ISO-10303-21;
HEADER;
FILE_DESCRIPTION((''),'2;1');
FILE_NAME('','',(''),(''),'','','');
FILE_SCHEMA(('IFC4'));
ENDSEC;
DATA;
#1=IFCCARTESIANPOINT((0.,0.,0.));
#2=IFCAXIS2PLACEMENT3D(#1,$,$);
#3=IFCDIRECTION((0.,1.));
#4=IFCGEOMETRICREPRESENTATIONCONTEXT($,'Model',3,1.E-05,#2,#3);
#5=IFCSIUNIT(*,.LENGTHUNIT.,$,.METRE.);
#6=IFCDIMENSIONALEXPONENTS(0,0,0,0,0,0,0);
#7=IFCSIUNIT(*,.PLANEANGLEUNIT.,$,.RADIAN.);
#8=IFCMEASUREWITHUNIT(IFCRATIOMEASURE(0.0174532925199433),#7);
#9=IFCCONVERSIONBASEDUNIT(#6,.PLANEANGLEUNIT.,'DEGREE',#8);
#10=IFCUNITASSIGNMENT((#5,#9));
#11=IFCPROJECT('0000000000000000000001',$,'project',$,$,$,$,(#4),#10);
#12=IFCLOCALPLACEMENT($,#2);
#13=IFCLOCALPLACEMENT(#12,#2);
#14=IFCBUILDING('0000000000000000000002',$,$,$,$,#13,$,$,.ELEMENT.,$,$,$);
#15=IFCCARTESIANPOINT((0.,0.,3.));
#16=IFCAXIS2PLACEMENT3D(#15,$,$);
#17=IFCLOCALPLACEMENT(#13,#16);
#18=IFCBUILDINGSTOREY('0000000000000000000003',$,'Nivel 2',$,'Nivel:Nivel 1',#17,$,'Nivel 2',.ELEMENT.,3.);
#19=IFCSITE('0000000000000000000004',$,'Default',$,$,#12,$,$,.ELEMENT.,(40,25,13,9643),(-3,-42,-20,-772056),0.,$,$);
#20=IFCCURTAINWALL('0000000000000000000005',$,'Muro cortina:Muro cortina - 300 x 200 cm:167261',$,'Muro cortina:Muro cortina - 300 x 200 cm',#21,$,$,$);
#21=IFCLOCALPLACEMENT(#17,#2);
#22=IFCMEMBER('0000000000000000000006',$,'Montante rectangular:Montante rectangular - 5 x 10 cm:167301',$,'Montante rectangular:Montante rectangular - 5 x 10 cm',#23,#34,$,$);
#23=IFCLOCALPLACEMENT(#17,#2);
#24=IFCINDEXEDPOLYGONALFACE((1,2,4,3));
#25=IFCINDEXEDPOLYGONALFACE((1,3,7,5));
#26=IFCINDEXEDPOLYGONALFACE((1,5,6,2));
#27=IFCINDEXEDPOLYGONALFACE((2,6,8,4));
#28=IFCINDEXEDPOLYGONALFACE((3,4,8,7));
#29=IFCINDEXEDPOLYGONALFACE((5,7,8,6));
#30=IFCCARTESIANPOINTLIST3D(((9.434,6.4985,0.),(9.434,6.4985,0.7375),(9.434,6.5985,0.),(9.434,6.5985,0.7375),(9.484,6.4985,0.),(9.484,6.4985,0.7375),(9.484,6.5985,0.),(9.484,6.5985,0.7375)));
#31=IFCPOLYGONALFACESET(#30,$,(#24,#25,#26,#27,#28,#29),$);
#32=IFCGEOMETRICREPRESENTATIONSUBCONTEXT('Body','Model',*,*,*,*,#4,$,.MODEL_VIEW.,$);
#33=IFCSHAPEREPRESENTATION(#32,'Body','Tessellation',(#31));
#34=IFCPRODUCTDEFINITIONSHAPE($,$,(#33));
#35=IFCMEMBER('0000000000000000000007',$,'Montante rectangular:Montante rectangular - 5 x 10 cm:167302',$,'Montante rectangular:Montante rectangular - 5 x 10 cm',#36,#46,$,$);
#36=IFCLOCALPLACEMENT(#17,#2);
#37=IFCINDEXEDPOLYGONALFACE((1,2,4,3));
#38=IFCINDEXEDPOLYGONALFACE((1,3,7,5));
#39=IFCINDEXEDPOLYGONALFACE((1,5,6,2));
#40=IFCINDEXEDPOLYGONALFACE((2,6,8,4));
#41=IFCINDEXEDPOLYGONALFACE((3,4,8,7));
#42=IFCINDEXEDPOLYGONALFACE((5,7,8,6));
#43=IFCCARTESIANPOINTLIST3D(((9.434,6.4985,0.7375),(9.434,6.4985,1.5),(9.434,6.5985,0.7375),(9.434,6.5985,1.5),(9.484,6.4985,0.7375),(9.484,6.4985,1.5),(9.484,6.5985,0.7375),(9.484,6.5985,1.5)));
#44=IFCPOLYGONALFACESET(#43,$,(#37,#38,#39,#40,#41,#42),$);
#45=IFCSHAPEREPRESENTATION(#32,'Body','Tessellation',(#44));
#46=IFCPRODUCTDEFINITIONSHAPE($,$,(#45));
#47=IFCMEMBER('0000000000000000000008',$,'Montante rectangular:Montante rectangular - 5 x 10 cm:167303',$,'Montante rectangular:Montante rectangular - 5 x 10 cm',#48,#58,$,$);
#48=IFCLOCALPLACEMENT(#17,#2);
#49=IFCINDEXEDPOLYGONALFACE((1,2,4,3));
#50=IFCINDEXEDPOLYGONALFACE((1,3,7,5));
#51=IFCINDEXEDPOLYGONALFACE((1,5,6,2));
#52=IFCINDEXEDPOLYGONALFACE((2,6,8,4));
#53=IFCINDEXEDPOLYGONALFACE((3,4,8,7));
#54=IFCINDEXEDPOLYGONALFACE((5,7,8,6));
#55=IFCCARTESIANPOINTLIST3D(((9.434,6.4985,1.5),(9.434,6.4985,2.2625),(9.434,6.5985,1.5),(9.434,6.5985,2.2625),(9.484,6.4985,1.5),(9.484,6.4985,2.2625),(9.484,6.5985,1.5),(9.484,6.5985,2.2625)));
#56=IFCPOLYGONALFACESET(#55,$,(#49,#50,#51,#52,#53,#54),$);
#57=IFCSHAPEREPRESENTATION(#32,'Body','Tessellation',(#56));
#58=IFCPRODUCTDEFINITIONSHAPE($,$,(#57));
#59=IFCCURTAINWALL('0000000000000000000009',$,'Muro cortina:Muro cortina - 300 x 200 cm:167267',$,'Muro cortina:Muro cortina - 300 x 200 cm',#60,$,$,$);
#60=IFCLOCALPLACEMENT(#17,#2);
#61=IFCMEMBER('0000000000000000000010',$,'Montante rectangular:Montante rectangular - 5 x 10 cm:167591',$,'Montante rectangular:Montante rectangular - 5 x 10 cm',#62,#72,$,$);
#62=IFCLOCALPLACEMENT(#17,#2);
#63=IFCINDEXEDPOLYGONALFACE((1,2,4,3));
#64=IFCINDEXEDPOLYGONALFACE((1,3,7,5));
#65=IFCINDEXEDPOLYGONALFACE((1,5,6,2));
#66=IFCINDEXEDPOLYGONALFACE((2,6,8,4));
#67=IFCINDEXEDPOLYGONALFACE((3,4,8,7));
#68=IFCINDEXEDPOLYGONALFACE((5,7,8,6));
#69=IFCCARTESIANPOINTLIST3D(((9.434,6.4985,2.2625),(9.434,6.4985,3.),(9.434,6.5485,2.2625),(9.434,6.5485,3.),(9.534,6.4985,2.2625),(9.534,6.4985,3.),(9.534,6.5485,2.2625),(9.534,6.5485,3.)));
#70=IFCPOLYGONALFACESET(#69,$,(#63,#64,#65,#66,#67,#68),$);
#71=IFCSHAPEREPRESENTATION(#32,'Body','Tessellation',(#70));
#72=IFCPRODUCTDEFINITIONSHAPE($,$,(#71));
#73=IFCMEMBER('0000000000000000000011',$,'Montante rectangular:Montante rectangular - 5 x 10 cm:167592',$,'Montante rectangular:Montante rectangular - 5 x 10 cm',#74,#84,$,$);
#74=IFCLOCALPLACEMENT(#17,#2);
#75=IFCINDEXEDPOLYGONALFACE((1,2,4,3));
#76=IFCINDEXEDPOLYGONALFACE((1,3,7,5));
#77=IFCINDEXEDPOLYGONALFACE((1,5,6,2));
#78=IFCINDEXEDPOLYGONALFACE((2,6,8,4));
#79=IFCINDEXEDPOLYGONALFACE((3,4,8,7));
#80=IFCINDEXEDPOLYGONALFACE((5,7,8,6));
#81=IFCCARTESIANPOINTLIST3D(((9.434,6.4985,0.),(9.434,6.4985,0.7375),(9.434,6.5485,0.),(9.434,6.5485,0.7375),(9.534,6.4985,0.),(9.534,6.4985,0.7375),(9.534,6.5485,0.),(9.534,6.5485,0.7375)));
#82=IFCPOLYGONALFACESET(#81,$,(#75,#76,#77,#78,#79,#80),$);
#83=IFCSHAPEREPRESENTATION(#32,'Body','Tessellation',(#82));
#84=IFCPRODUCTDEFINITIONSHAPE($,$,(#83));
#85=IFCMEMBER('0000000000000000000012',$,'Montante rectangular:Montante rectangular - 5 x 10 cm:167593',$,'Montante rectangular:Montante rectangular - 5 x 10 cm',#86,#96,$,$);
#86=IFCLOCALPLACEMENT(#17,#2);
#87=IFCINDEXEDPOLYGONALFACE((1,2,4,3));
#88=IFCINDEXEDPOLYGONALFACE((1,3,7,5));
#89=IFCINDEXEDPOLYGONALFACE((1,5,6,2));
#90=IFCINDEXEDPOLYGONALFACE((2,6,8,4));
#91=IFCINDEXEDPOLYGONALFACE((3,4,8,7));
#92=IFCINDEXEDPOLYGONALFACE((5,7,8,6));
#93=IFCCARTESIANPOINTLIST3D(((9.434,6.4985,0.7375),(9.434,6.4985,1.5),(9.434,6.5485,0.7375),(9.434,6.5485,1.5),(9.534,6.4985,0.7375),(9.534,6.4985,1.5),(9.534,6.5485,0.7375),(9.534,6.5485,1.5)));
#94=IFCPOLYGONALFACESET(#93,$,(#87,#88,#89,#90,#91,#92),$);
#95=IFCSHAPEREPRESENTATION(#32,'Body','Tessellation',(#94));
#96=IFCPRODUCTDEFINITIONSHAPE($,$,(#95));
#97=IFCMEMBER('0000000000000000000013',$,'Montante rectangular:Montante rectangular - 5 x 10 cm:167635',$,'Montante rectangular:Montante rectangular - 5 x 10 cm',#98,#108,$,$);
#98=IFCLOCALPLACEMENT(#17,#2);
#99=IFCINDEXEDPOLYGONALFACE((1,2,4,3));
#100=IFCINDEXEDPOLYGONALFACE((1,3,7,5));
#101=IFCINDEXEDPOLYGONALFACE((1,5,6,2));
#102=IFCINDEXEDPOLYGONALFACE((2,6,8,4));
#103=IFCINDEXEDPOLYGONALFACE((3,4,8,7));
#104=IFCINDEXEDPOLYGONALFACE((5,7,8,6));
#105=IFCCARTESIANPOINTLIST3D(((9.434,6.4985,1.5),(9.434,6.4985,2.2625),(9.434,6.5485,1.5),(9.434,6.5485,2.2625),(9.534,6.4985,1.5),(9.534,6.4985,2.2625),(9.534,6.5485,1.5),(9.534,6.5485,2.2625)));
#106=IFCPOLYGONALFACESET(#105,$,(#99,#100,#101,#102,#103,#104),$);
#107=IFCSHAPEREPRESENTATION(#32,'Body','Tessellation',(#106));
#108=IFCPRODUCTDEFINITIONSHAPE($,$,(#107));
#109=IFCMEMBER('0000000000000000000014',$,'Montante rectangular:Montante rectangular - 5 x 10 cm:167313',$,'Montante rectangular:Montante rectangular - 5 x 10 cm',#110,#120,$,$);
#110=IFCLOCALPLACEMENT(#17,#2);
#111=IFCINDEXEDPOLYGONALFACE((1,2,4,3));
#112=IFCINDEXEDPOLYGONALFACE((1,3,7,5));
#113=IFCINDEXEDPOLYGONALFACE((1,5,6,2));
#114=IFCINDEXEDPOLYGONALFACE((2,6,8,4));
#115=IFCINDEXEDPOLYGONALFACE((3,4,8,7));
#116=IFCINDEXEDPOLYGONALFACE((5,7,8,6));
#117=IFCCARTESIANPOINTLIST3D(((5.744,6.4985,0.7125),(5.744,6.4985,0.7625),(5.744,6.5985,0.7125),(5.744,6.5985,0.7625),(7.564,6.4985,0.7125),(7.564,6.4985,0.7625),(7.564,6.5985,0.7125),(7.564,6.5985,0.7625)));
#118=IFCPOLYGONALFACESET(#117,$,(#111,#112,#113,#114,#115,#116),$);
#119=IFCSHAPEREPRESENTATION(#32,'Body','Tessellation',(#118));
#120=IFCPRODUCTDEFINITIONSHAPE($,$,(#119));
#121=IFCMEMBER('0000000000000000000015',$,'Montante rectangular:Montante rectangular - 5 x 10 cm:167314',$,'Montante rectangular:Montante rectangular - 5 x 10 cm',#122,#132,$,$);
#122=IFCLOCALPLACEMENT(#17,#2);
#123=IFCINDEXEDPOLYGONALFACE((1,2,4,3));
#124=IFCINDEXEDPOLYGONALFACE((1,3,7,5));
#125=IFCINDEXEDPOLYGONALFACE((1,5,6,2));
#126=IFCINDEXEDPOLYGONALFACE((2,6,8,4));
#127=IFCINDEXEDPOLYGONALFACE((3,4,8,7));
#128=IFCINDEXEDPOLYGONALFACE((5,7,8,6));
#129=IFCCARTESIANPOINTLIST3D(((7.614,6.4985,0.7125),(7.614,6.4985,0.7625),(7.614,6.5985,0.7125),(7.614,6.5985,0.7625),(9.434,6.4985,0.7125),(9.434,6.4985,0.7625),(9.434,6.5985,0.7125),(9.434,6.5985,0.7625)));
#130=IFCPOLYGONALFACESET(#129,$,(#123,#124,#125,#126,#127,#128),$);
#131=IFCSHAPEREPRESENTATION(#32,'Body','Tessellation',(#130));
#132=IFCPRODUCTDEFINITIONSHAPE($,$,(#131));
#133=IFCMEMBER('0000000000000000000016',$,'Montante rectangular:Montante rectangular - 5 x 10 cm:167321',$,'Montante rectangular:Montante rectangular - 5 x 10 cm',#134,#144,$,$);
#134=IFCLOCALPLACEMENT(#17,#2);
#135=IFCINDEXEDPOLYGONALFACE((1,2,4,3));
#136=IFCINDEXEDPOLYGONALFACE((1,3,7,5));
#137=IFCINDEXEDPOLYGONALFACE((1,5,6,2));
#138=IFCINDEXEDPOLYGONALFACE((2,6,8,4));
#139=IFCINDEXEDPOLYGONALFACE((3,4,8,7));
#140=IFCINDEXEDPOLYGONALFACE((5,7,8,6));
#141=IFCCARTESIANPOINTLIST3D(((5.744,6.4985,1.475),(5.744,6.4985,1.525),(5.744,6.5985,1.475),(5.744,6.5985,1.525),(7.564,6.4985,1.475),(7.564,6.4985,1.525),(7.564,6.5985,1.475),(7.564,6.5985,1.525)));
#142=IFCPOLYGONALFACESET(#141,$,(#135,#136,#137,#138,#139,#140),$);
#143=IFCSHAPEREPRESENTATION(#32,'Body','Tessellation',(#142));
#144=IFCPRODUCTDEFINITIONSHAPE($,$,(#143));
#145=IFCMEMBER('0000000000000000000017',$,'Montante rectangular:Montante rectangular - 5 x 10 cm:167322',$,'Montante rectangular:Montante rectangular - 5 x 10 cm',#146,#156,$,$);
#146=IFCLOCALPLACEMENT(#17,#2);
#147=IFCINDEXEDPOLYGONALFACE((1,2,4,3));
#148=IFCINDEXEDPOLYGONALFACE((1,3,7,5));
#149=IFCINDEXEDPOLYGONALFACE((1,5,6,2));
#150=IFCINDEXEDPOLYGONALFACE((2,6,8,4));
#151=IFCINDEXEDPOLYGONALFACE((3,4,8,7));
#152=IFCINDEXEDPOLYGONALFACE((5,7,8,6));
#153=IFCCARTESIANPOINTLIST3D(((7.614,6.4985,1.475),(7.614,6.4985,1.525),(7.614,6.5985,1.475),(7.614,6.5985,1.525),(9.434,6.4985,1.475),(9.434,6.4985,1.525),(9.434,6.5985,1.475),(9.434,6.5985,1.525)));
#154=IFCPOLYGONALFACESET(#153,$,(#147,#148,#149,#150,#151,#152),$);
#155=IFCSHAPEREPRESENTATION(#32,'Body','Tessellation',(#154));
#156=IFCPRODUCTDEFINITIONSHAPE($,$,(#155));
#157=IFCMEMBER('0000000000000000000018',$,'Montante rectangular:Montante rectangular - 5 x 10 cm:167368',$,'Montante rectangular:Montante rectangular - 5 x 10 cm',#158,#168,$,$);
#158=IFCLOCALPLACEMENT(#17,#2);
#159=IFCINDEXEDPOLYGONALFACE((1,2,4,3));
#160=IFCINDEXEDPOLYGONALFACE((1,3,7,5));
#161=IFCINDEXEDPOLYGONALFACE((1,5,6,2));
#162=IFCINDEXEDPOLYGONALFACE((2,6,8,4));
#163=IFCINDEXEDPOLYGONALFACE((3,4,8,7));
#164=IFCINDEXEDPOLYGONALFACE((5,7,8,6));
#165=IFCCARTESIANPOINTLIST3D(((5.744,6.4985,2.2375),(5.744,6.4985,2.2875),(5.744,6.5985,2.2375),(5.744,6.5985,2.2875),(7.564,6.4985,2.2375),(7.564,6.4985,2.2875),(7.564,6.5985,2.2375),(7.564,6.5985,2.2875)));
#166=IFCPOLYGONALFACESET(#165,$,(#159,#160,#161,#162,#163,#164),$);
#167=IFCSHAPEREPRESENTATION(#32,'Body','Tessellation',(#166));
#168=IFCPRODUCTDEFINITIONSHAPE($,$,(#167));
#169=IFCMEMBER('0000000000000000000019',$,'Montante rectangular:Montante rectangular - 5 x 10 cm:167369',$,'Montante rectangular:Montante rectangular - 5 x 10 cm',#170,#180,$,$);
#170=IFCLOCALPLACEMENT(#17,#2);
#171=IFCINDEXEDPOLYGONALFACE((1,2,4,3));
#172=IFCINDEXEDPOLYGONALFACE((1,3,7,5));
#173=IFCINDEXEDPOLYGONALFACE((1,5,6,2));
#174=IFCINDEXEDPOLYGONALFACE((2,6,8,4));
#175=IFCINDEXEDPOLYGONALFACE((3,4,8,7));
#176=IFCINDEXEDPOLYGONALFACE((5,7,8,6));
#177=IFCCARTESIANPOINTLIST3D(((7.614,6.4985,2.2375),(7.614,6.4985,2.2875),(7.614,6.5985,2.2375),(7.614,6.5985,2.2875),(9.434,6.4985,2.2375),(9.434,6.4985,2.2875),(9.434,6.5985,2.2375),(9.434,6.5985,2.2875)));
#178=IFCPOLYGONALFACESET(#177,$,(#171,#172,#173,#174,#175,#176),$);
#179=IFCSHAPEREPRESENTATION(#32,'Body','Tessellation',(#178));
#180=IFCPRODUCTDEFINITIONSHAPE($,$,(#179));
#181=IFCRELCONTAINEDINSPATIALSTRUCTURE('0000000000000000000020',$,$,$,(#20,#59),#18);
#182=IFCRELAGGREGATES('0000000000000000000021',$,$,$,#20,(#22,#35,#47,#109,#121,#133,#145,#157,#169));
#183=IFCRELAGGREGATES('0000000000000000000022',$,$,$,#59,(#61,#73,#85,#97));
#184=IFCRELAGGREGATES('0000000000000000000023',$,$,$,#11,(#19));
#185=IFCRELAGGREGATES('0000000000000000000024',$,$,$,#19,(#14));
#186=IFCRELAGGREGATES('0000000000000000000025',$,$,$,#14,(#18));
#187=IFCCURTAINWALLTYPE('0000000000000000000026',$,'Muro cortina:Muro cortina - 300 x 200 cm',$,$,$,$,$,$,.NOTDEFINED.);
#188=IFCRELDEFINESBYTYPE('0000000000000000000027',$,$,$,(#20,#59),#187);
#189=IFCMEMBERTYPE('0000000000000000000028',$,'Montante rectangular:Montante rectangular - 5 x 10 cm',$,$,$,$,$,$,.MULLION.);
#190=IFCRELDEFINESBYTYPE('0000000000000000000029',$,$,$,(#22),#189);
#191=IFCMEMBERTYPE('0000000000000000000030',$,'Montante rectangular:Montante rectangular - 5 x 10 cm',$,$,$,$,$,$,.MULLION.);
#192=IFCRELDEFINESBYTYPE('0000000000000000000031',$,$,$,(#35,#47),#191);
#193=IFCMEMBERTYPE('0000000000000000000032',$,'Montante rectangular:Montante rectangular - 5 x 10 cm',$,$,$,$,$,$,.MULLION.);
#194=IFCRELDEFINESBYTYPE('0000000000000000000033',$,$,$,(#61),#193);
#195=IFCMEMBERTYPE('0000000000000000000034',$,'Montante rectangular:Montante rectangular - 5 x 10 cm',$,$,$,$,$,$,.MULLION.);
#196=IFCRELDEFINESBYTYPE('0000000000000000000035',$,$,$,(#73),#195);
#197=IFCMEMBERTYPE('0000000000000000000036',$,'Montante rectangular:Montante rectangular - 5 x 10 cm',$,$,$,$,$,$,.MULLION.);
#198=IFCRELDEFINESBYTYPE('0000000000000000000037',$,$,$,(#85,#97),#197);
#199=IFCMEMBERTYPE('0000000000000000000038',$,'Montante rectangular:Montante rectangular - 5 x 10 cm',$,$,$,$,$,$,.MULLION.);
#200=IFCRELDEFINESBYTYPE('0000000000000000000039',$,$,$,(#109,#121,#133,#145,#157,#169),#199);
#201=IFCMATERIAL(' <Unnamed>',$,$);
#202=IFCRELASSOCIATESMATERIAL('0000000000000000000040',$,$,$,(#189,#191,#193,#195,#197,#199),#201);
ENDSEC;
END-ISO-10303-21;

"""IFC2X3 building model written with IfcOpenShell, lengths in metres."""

from ifc_helpers import new_model, entity, si_unit, converted_unit, direction, frame, origin, origin_2d_with_axis, place, context, subcontext, project, spatial, rectangle, extrude, source, transform, mapped, material, type_object, type_shapes, element, aggregate, save


model = new_model("IFC2X3")

# Units and contexts
model_context = context("Model", 3, precision=1e-05, world=origin(), true_north=direction((0.0, 1.0)))
body_context = subcontext(model_context, "Body", "Model", "MODEL_VIEW")
ifc_project = project(units=[si_unit("LENGTHUNIT", "METRE"), converted_unit("PLANEANGLEUNIT", "DEGREE", entity("IfcRatioMeasure", 0.0174532925199433), si_unit("PLANEANGLEUNIT", "RADIAN"), dimensions=[0, 0, 0, 0, 0, 0, 0])], contexts=[model_context])

# Site, building, storey
site_placement = place(None, origin())
site = spatial("IfcSite", under=ifc_project, at=site_placement, Name="Default", CompositionType="ELEMENT", RefLatitude=(40, 25, 13, 9643), RefLongitude=(-3, -42, -20, -772056), RefElevation=0.0)
building_placement = place(site_placement, origin())
building = spatial("IfcBuilding", under=site, at=building_placement, CompositionType="ELEMENT")
storey_placement = place(building_placement, frame((0.0, 0.0, 3.0)))
storey = spatial("IfcBuildingStorey", under=building, at=storey_placement, Name="Nivel 2", ObjectType="Nivel:Nivel 1", LongName="Nivel 2", CompositionType="ELEMENT", Elevation=3.0)

# Curtain walls, members
curtain_wall_type = type_object("IfcCurtainWallType", Name="Muro cortina:Muro cortina - 300 x 200 cm", PredefinedType="NOTDEFINED")
curtain_wall_1_placement = place(storey_placement, frame((0.0, 0.0, -3.0)))
curtain_wall_1 = element("IfcCurtainWall", 1, at=curtain_wall_1_placement, inside=storey, type_object=curtain_wall_type, Name="Muro cortina:Muro cortina - 300 x 200 cm:167261", ObjectType="Muro cortina:Muro cortina - 300 x 200 cm")
ifc_material_1 = material(Name=" <Unnamed>")
member_type_1 = type_object("IfcMemberType", Name="Montante rectangular:Montante rectangular - 5 x 10 cm", PredefinedType="MULLION", material=ifc_material_1)
shared_shape_1 = source(origin(), body_context, "Body", "SweptSolid", [
    extrude(rectangle(XDim=0.1, YDim=0.05, at=origin_2d_with_axis()), frame((-0.025, 0.0, -0.7375), z_axis=(0.0, 0.0, 1.0), x_axis=(0.0, -1.0, 0.0)), (0.0, 0.0, 1.0), 0.7375),
])
type_shapes(member_type_1, [shared_shape_1])
member_1_placement = place(storey_placement, frame((9.484, 6.5485, 0.0), z_axis=(0.0, 0.0, -1.0), x_axis=(1.0, 0.0, 0.0)))
member_1 = element("IfcMember", 2, at=member_1_placement, type_object=member_type_1, Name="Montante rectangular:Montante rectangular - 5 x 10 cm:167301", ObjectType="Montante rectangular:Montante rectangular - 5 x 10 cm", context=body_context, shape_type="MappedRepresentation", body=[
    mapped(shared_shape_1, transform((0.0, 0.0, 0.0), scale=1.0)),
])
member_type_2 = type_object("IfcMemberType", Name="Montante rectangular:Montante rectangular - 5 x 10 cm", PredefinedType="MULLION", material=ifc_material_1)
shared_shape_2 = source(origin(), body_context, "Body", "SweptSolid", [
    extrude(rectangle(XDim=0.1, YDim=0.05, at=origin_2d_with_axis()), frame((-0.025, 0.0, -0.7625), z_axis=(0.0, 0.0, 1.0), x_axis=(0.0, -1.0, 0.0)), (0.0, 0.0, 1.0), 0.7625),
])
type_shapes(member_type_2, [shared_shape_2])
member_2_placement = place(storey_placement, frame((9.484, 6.5485, 0.7375), z_axis=(0.0, 0.0, -1.0), x_axis=(1.0, 0.0, 0.0)))
member_2 = element("IfcMember", 3, at=member_2_placement, type_object=member_type_2, Name="Montante rectangular:Montante rectangular - 5 x 10 cm:167302", ObjectType="Montante rectangular:Montante rectangular - 5 x 10 cm", context=body_context, shape_type="MappedRepresentation", body=[
    mapped(shared_shape_2, transform((0.0, 0.0, 0.0), scale=1.0)),
])
member_3_placement = place(storey_placement, frame((9.484, 6.5485, 1.5), z_axis=(0.0, 0.0, -1.0), x_axis=(1.0, 0.0, 0.0)))
member_3 = element("IfcMember", 4, at=member_3_placement, type_object=member_type_2, Name="Montante rectangular:Montante rectangular - 5 x 10 cm:167303", ObjectType="Montante rectangular:Montante rectangular - 5 x 10 cm", context=body_context, shape_type="MappedRepresentation", body=[
    mapped(shared_shape_2, transform((0.0, 0.0, 0.0), scale=1.0)),
])
curtain_wall_2_placement = place(storey_placement, frame((0.0, 0.0, -3.0)))
curtain_wall_2 = element("IfcCurtainWall", 5, at=curtain_wall_2_placement, inside=storey, type_object=curtain_wall_type, Name="Muro cortina:Muro cortina - 300 x 200 cm:167267", ObjectType="Muro cortina:Muro cortina - 300 x 200 cm")
member_type_3 = type_object("IfcMemberType", Name="Montante rectangular:Montante rectangular - 5 x 10 cm", PredefinedType="MULLION", material=ifc_material_1)
shared_shape_3 = source(origin(), body_context, "Body", "SweptSolid", [
    extrude(rectangle(XDim=0.1, YDim=0.05, at=origin_2d_with_axis()), frame((-0.025, 0.0, -0.7375), z_axis=(0.0, 0.0, 1.0), x_axis=(0.0, -1.0, 0.0)), (0.0, 0.0, 1.0), 0.7375),
])
type_shapes(member_type_3, [shared_shape_3])
member_4_placement = place(storey_placement, frame((9.484, 6.5485, 3.0), z_axis=(0.0, 0.0, 1.0), x_axis=(0.0, 1.0, 0.0)))
member_4 = element("IfcMember", 6, at=member_4_placement, type_object=member_type_3, Name="Montante rectangular:Montante rectangular - 5 x 10 cm:167591", ObjectType="Montante rectangular:Montante rectangular - 5 x 10 cm", context=body_context, shape_type="MappedRepresentation", body=[
    mapped(shared_shape_3, transform((0.0, 0.0, 0.0), scale=1.0)),
])
member_type_4 = type_object("IfcMemberType", Name="Montante rectangular:Montante rectangular - 5 x 10 cm", PredefinedType="MULLION", material=ifc_material_1)
shared_shape_4 = source(origin(), body_context, "Body", "SweptSolid", [
    extrude(rectangle(XDim=0.1, YDim=0.05, at=origin_2d_with_axis()), frame((-0.025, 0.0, -0.7375), z_axis=(0.0, 0.0, 1.0), x_axis=(0.0, -1.0, 0.0)), (0.0, 0.0, 1.0), 0.7375),
])
type_shapes(member_type_4, [shared_shape_4])
member_5_placement = place(storey_placement, frame((9.484, 6.5485, 0.7375), z_axis=(0.0, 0.0, 1.0), x_axis=(0.0, 1.0, 0.0)))
member_5 = element("IfcMember", 7, at=member_5_placement, type_object=member_type_4, Name="Montante rectangular:Montante rectangular - 5 x 10 cm:167592", ObjectType="Montante rectangular:Montante rectangular - 5 x 10 cm", context=body_context, shape_type="MappedRepresentation", body=[
    mapped(shared_shape_4, transform((0.0, 0.0, 0.0), scale=1.0)),
])
member_type_5 = type_object("IfcMemberType", Name="Montante rectangular:Montante rectangular - 5 x 10 cm", PredefinedType="MULLION", material=ifc_material_1)
shared_shape_5 = source(origin(), body_context, "Body", "SweptSolid", [
    extrude(rectangle(XDim=0.1, YDim=0.05, at=origin_2d_with_axis()), frame((-0.025, 0.0, -0.7625), z_axis=(0.0, 0.0, 1.0), x_axis=(0.0, -1.0, 0.0)), (0.0, 0.0, 1.0), 0.7625),
])
type_shapes(member_type_5, [shared_shape_5])
member_6_placement = place(storey_placement, frame((9.484, 6.5485, 1.5), z_axis=(0.0, 0.0, 1.0), x_axis=(0.0, 1.0, 0.0)))
member_6 = element("IfcMember", 8, at=member_6_placement, type_object=member_type_5, Name="Montante rectangular:Montante rectangular - 5 x 10 cm:167593", ObjectType="Montante rectangular:Montante rectangular - 5 x 10 cm", context=body_context, shape_type="MappedRepresentation", body=[
    mapped(shared_shape_5, transform((0.0, 0.0, 0.0), scale=1.0)),
])
member_7_placement = place(storey_placement, frame((9.484, 6.5485, 2.2625), z_axis=(0.0, 0.0, 1.0), x_axis=(0.0, 1.0, 0.0)))
member_7 = element("IfcMember", 9, at=member_7_placement, type_object=member_type_5, Name="Montante rectangular:Montante rectangular - 5 x 10 cm:167635", ObjectType="Montante rectangular:Montante rectangular - 5 x 10 cm", context=body_context, shape_type="MappedRepresentation", body=[
    mapped(shared_shape_5, transform((0.0, 0.0, 0.0), scale=1.0)),
])

# Members
member_type_6 = type_object("IfcMemberType", Name="Montante rectangular:Montante rectangular - 5 x 10 cm", PredefinedType="MULLION", material=ifc_material_1)
shared_shape_6 = source(origin(), body_context, "Body", "SweptSolid", [
    extrude(rectangle(XDim=0.1, YDim=0.05, at=origin_2d_with_axis()), frame((0.0, 0.0, -1.82), z_axis=(0.0, 0.0, 1.0), x_axis=(0.0, -1.0, 0.0)), (0.0, 0.0, 1.0), 1.82),
])
type_shapes(member_type_6, [shared_shape_6])
member_8_placement = place(storey_placement, frame((7.564, 6.5485, 0.7375), z_axis=(1.0, 0.0, 0.0), x_axis=(0.0, 0.0, 1.0)))
member_8 = element("IfcMember", 10, at=member_8_placement, type_object=member_type_6, Name="Montante rectangular:Montante rectangular - 5 x 10 cm:167313", ObjectType="Montante rectangular:Montante rectangular - 5 x 10 cm", context=body_context, shape_type="MappedRepresentation", body=[
    mapped(shared_shape_6, transform((0.0, 0.0, 0.0), scale=1.0)),
])
member_9_placement = place(storey_placement, frame((9.434, 6.5485, 0.7375), z_axis=(1.0, 0.0, 0.0), x_axis=(0.0, 0.0, 1.0)))
member_9 = element("IfcMember", 11, at=member_9_placement, type_object=member_type_6, Name="Montante rectangular:Montante rectangular - 5 x 10 cm:167314", ObjectType="Montante rectangular:Montante rectangular - 5 x 10 cm", context=body_context, shape_type="MappedRepresentation", body=[
    mapped(shared_shape_6, transform((0.0, 0.0, 0.0), scale=1.0)),
])
member_10_placement = place(storey_placement, frame((7.564, 6.5485, 1.5), z_axis=(1.0, 0.0, 0.0), x_axis=(0.0, 0.0, 1.0)))
member_10 = element("IfcMember", 12, at=member_10_placement, type_object=member_type_6, Name="Montante rectangular:Montante rectangular - 5 x 10 cm:167321", ObjectType="Montante rectangular:Montante rectangular - 5 x 10 cm", context=body_context, shape_type="MappedRepresentation", body=[
    mapped(shared_shape_6, transform((0.0, 0.0, 0.0), scale=1.0)),
])
member_11_placement = place(storey_placement, frame((9.434, 6.5485, 1.5), z_axis=(1.0, 0.0, 0.0), x_axis=(0.0, 0.0, 1.0)))
member_11 = element("IfcMember", 13, at=member_11_placement, type_object=member_type_6, Name="Montante rectangular:Montante rectangular - 5 x 10 cm:167322", ObjectType="Montante rectangular:Montante rectangular - 5 x 10 cm", context=body_context, shape_type="MappedRepresentation", body=[
    mapped(shared_shape_6, transform((0.0, 0.0, 0.0), scale=1.0)),
])
member_12_placement = place(storey_placement, frame((7.564, 6.5485, 2.2625), z_axis=(1.0, 0.0, 0.0), x_axis=(0.0, 0.0, 1.0)))
member_12 = element("IfcMember", 14, at=member_12_placement, type_object=member_type_6, Name="Montante rectangular:Montante rectangular - 5 x 10 cm:167368", ObjectType="Montante rectangular:Montante rectangular - 5 x 10 cm", context=body_context, shape_type="MappedRepresentation", body=[
    mapped(shared_shape_6, transform((0.0, 0.0, 0.0), scale=1.0)),
])
member_13_placement = place(storey_placement, frame((9.434, 6.5485, 2.2625), z_axis=(1.0, 0.0, 0.0), x_axis=(0.0, 0.0, 1.0)))
member_13 = element("IfcMember", 15, at=member_13_placement, type_object=member_type_6, Name="Montante rectangular:Montante rectangular - 5 x 10 cm:167369", ObjectType="Montante rectangular:Montante rectangular - 5 x 10 cm", context=body_context, shape_type="MappedRepresentation", body=[
    mapped(shared_shape_6, transform((0.0, 0.0, 0.0), scale=1.0)),
])

aggregate(curtain_wall_1, [member_1, member_2, member_3, member_8, member_9, member_10, member_11, member_12, member_13])
aggregate(curtain_wall_2, [member_4, member_5, member_6, member_7])

save(model, "model.ifc")
